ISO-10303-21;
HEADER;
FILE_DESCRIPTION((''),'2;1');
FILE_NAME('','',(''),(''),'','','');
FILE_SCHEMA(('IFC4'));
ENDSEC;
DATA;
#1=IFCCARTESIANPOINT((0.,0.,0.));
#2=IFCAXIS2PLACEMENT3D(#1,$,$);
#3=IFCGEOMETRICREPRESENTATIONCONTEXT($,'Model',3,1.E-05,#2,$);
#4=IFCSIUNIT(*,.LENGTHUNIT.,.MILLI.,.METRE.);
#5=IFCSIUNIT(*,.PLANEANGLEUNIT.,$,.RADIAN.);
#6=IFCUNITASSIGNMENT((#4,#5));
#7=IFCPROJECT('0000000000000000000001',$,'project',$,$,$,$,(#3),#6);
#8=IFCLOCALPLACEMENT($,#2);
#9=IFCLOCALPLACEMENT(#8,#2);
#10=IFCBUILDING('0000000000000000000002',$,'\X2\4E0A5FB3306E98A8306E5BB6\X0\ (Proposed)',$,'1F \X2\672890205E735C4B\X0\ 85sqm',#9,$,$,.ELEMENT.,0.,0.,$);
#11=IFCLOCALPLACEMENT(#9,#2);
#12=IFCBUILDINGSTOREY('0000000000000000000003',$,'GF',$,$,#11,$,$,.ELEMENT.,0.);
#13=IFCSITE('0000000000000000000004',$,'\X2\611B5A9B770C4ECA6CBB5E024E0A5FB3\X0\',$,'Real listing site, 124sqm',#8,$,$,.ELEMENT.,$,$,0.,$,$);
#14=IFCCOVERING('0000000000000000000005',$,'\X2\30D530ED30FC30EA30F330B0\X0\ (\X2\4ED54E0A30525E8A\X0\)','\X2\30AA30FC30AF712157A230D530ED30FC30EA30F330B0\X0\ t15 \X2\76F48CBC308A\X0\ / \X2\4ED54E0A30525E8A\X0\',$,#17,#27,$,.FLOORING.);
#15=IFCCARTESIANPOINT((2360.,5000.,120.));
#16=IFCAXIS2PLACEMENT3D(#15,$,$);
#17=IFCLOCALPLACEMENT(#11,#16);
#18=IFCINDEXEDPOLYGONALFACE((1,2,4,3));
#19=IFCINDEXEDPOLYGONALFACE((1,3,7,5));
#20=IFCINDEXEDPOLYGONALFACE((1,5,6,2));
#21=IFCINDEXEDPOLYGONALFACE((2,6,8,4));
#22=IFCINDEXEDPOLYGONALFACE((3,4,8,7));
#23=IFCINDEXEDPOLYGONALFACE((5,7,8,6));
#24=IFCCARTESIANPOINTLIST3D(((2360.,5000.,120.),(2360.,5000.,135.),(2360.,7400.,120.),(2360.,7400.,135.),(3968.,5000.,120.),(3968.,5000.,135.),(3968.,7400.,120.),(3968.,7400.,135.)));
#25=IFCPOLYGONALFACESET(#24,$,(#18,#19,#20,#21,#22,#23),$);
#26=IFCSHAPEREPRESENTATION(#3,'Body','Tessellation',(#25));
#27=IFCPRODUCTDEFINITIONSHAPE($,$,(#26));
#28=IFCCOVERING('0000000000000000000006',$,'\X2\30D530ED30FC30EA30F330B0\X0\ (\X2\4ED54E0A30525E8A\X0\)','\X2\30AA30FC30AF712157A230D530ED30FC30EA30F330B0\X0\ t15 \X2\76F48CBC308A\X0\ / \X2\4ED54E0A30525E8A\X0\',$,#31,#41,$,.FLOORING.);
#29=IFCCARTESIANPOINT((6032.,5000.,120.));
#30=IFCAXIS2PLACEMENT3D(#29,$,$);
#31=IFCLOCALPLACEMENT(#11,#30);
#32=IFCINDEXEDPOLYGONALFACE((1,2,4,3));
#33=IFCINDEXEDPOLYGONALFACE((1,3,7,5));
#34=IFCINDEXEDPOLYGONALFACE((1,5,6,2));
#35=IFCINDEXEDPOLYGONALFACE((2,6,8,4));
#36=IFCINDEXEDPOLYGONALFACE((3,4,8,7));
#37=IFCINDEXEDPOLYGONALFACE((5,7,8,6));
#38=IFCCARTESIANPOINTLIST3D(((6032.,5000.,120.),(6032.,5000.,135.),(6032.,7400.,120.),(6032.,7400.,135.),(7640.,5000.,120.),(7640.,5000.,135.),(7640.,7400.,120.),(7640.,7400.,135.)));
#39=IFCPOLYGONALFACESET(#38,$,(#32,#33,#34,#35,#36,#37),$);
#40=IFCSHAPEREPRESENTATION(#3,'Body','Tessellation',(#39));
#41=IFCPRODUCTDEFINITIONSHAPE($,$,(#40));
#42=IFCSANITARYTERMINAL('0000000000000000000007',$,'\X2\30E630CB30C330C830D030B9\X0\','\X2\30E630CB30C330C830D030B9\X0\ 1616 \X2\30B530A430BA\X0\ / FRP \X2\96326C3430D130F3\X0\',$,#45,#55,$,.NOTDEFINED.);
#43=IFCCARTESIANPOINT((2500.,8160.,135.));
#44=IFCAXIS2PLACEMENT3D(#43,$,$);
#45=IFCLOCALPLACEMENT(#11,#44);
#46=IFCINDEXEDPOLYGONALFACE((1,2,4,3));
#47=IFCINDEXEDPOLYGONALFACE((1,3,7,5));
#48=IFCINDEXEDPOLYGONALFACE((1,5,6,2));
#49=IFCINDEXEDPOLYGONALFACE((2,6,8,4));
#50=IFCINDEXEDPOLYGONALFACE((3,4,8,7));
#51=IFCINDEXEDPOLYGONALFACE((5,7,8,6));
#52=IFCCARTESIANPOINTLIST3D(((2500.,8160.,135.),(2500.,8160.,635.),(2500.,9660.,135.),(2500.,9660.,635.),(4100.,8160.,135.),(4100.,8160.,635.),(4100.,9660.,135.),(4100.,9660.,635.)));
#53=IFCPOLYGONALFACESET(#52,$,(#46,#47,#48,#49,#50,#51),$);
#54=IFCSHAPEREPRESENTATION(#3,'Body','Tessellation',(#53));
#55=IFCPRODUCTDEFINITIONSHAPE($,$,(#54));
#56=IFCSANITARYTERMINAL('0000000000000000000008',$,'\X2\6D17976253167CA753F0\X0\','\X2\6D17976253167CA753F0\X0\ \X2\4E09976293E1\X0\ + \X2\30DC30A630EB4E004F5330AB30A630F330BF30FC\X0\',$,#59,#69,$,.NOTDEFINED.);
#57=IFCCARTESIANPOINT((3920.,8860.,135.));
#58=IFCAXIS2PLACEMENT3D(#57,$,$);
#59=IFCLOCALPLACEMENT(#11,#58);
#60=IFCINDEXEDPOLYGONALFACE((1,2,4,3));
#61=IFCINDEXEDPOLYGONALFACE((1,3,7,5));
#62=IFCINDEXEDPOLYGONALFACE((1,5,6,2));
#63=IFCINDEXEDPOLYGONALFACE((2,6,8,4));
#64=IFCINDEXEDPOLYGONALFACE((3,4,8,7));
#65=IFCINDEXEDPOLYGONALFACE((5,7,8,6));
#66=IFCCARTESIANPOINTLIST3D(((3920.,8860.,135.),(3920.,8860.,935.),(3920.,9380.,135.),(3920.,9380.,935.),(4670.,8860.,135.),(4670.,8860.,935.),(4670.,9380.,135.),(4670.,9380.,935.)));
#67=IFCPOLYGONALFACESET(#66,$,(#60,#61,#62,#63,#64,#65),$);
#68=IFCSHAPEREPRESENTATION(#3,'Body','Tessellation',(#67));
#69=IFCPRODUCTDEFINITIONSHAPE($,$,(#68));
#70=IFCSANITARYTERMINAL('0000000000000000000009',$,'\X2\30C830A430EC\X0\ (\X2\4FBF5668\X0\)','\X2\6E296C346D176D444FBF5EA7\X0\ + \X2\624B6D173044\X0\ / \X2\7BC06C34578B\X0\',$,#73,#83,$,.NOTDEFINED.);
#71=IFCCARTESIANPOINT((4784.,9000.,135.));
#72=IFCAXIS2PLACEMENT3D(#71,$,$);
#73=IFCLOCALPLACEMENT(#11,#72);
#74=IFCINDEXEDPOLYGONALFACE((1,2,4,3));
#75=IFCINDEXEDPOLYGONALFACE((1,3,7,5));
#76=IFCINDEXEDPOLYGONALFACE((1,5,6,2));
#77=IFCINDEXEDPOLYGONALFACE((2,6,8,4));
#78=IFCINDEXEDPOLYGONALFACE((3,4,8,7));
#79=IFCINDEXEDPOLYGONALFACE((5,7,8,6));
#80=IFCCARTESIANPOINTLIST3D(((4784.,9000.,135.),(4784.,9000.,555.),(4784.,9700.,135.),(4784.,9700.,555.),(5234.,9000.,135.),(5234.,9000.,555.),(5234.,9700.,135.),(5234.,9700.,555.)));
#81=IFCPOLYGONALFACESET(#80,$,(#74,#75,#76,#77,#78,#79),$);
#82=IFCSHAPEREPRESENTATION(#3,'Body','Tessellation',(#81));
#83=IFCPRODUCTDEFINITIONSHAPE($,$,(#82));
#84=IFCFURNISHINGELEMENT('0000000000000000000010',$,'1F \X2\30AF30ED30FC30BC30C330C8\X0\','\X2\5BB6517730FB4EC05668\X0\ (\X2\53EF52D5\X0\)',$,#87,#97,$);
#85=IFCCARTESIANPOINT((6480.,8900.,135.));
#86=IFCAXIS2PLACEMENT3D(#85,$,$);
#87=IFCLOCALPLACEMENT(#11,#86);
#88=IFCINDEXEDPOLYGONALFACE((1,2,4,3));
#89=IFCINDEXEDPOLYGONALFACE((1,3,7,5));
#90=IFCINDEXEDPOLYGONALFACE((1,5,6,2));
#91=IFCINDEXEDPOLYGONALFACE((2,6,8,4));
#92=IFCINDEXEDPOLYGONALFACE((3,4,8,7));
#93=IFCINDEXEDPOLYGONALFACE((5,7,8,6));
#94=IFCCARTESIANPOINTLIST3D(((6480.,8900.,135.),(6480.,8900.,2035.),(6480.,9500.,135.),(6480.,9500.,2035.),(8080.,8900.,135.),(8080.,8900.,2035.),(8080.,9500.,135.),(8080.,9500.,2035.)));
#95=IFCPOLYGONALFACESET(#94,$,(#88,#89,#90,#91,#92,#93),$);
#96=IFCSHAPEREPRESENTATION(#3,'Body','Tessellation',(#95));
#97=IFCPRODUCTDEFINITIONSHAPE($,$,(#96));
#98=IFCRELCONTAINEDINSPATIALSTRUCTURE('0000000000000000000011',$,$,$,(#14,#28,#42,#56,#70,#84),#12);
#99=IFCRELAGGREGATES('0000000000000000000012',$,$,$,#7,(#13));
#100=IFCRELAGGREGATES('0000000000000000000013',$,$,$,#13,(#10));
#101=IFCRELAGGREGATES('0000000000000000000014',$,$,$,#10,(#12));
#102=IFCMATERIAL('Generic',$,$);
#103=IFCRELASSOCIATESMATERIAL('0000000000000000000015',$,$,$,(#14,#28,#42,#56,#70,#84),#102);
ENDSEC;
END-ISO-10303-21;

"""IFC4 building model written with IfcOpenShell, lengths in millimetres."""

from ifc_helpers import new_model, si_unit, frame, frame_2d, origin, place, context, project, spatial, rectangle, extrude, material, element, save


model = new_model("IFC4")

# Units and contexts
model_context = context("Model", 3, precision=1e-05, world=origin())
ifc_project = project(units=[si_unit("LENGTHUNIT", "METRE", prefix="MILLI"), si_unit("PLANEANGLEUNIT", "RADIAN")], contexts=[model_context])

# Site, building, storey
site_placement = place(None, origin())
site = spatial("IfcSite", under=ifc_project, at=site_placement, Name="愛媛県今治市上徳", ObjectType="Real listing site, 124sqm", CompositionType="ELEMENT", RefElevation=0.0)
building_placement = place(site_placement, origin())
building = spatial("IfcBuilding", under=site, at=building_placement, Name="上徳の風の家 (Proposed)", ObjectType="1F 木造平屋 85sqm", CompositionType="ELEMENT", ElevationOfRefHeight=0.0, ElevationOfTerrain=0.0)
storey_placement = place(building_placement, origin())
storey = spatial("IfcBuildingStorey", under=building, at=storey_placement, Name="GF", CompositionType="ELEMENT", Elevation=0.0)

# Coverings
ifc_material_1 = material(Name="Generic")
covering_1_placement = place(storey_placement, frame((2360.0, 5000.0, 120.0)))
element("IfcCovering", 1, at=covering_1_placement, inside=storey, material=ifc_material_1, Name="フローリング (仕上げ床)", Description="オーク無垢フローリング t15 直貼り / 仕上げ床", PredefinedType="FLOORING", context=model_context, shape_type="SweptSolid", body=[
    extrude(rectangle(XDim=1608.0, YDim=2400.0, at=frame_2d((804.0, 1200.0))), frame((2360.0, 5000.0, 120.0)), (0.0, 0.0, 1.0), 15.0),
])
covering_2_placement = place(storey_placement, frame((6032.0, 5000.0, 120.0)))
element("IfcCovering", 2, at=covering_2_placement, inside=storey, material=ifc_material_1, Name="フローリング (仕上げ床)", Description="オーク無垢フローリング t15 直貼り / 仕上げ床", PredefinedType="FLOORING", context=model_context, shape_type="SweptSolid", body=[
    extrude(rectangle(XDim=1608.0, YDim=2400.0, at=frame_2d((804.0, 1200.0))), frame((6032.0, 5000.0, 120.0)), (0.0, 0.0, 1.0), 15.0),
])

# Sanitary terminals
sanitary_terminal_1_placement = place(storey_placement, frame((2500.0, 8160.0, 135.0)))
element("IfcSanitaryTerminal", 3, at=sanitary_terminal_1_placement, inside=storey, material=ifc_material_1, Name="ユニットバス", Description="ユニットバス 1616 サイズ / FRP 防水パン", PredefinedType="NOTDEFINED", context=model_context, shape_type="SweptSolid", body=[
    extrude(rectangle(XDim=1600.0, YDim=1500.0, at=frame_2d((800.0, 750.0))), frame((2500.0, 8160.0, 135.0)), (0.0, 0.0, 1.0), 500.0),
])
sanitary_terminal_2_placement = place(storey_placement, frame((3920.0, 8860.0, 135.0)))
element("IfcSanitaryTerminal", 4, at=sanitary_terminal_2_placement, inside=storey, material=ifc_material_1, Name="洗面化粧台", Description="洗面化粧台 三面鏡 + ボウル一体カウンター", PredefinedType="NOTDEFINED", context=model_context, shape_type="SweptSolid", body=[
    extrude(rectangle(XDim=750.0, YDim=520.0, at=frame_2d((375.0, 260.0))), frame((3920.0, 8860.0, 135.0)), (0.0, 0.0, 1.0), 800.0),
])
sanitary_terminal_3_placement = place(storey_placement, frame((4784.0, 9000.0, 135.0)))
element("IfcSanitaryTerminal", 5, at=sanitary_terminal_3_placement, inside=storey, material=ifc_material_1, Name="トイレ (便器)", Description="温水洗浄便座 + 手洗い / 節水型", PredefinedType="NOTDEFINED", context=model_context, shape_type="SweptSolid", body=[
    extrude(rectangle(XDim=450.0, YDim=700.0, at=frame_2d((225.0, 350.0))), frame((4784.0, 9000.0, 135.0)), (0.0, 0.0, 1.0), 420.0),
])

# Furnishing element
furnishing_placement = place(storey_placement, frame((6480.0, 8900.0, 135.0)))
element("IfcFurnishingElement", 6, at=furnishing_placement, inside=storey, material=ifc_material_1, Name="1F クローゼット", Description="家具・什器 (可動)", context=model_context, shape_type="SweptSolid", body=[
    extrude(rectangle(XDim=1600.0, YDim=600.0, at=frame_2d((800.0, 300.0))), frame((6480.0, 8900.0, 135.0)), (0.0, 0.0, 1.0), 1900.0),
])

save(model, "model.ifc")
